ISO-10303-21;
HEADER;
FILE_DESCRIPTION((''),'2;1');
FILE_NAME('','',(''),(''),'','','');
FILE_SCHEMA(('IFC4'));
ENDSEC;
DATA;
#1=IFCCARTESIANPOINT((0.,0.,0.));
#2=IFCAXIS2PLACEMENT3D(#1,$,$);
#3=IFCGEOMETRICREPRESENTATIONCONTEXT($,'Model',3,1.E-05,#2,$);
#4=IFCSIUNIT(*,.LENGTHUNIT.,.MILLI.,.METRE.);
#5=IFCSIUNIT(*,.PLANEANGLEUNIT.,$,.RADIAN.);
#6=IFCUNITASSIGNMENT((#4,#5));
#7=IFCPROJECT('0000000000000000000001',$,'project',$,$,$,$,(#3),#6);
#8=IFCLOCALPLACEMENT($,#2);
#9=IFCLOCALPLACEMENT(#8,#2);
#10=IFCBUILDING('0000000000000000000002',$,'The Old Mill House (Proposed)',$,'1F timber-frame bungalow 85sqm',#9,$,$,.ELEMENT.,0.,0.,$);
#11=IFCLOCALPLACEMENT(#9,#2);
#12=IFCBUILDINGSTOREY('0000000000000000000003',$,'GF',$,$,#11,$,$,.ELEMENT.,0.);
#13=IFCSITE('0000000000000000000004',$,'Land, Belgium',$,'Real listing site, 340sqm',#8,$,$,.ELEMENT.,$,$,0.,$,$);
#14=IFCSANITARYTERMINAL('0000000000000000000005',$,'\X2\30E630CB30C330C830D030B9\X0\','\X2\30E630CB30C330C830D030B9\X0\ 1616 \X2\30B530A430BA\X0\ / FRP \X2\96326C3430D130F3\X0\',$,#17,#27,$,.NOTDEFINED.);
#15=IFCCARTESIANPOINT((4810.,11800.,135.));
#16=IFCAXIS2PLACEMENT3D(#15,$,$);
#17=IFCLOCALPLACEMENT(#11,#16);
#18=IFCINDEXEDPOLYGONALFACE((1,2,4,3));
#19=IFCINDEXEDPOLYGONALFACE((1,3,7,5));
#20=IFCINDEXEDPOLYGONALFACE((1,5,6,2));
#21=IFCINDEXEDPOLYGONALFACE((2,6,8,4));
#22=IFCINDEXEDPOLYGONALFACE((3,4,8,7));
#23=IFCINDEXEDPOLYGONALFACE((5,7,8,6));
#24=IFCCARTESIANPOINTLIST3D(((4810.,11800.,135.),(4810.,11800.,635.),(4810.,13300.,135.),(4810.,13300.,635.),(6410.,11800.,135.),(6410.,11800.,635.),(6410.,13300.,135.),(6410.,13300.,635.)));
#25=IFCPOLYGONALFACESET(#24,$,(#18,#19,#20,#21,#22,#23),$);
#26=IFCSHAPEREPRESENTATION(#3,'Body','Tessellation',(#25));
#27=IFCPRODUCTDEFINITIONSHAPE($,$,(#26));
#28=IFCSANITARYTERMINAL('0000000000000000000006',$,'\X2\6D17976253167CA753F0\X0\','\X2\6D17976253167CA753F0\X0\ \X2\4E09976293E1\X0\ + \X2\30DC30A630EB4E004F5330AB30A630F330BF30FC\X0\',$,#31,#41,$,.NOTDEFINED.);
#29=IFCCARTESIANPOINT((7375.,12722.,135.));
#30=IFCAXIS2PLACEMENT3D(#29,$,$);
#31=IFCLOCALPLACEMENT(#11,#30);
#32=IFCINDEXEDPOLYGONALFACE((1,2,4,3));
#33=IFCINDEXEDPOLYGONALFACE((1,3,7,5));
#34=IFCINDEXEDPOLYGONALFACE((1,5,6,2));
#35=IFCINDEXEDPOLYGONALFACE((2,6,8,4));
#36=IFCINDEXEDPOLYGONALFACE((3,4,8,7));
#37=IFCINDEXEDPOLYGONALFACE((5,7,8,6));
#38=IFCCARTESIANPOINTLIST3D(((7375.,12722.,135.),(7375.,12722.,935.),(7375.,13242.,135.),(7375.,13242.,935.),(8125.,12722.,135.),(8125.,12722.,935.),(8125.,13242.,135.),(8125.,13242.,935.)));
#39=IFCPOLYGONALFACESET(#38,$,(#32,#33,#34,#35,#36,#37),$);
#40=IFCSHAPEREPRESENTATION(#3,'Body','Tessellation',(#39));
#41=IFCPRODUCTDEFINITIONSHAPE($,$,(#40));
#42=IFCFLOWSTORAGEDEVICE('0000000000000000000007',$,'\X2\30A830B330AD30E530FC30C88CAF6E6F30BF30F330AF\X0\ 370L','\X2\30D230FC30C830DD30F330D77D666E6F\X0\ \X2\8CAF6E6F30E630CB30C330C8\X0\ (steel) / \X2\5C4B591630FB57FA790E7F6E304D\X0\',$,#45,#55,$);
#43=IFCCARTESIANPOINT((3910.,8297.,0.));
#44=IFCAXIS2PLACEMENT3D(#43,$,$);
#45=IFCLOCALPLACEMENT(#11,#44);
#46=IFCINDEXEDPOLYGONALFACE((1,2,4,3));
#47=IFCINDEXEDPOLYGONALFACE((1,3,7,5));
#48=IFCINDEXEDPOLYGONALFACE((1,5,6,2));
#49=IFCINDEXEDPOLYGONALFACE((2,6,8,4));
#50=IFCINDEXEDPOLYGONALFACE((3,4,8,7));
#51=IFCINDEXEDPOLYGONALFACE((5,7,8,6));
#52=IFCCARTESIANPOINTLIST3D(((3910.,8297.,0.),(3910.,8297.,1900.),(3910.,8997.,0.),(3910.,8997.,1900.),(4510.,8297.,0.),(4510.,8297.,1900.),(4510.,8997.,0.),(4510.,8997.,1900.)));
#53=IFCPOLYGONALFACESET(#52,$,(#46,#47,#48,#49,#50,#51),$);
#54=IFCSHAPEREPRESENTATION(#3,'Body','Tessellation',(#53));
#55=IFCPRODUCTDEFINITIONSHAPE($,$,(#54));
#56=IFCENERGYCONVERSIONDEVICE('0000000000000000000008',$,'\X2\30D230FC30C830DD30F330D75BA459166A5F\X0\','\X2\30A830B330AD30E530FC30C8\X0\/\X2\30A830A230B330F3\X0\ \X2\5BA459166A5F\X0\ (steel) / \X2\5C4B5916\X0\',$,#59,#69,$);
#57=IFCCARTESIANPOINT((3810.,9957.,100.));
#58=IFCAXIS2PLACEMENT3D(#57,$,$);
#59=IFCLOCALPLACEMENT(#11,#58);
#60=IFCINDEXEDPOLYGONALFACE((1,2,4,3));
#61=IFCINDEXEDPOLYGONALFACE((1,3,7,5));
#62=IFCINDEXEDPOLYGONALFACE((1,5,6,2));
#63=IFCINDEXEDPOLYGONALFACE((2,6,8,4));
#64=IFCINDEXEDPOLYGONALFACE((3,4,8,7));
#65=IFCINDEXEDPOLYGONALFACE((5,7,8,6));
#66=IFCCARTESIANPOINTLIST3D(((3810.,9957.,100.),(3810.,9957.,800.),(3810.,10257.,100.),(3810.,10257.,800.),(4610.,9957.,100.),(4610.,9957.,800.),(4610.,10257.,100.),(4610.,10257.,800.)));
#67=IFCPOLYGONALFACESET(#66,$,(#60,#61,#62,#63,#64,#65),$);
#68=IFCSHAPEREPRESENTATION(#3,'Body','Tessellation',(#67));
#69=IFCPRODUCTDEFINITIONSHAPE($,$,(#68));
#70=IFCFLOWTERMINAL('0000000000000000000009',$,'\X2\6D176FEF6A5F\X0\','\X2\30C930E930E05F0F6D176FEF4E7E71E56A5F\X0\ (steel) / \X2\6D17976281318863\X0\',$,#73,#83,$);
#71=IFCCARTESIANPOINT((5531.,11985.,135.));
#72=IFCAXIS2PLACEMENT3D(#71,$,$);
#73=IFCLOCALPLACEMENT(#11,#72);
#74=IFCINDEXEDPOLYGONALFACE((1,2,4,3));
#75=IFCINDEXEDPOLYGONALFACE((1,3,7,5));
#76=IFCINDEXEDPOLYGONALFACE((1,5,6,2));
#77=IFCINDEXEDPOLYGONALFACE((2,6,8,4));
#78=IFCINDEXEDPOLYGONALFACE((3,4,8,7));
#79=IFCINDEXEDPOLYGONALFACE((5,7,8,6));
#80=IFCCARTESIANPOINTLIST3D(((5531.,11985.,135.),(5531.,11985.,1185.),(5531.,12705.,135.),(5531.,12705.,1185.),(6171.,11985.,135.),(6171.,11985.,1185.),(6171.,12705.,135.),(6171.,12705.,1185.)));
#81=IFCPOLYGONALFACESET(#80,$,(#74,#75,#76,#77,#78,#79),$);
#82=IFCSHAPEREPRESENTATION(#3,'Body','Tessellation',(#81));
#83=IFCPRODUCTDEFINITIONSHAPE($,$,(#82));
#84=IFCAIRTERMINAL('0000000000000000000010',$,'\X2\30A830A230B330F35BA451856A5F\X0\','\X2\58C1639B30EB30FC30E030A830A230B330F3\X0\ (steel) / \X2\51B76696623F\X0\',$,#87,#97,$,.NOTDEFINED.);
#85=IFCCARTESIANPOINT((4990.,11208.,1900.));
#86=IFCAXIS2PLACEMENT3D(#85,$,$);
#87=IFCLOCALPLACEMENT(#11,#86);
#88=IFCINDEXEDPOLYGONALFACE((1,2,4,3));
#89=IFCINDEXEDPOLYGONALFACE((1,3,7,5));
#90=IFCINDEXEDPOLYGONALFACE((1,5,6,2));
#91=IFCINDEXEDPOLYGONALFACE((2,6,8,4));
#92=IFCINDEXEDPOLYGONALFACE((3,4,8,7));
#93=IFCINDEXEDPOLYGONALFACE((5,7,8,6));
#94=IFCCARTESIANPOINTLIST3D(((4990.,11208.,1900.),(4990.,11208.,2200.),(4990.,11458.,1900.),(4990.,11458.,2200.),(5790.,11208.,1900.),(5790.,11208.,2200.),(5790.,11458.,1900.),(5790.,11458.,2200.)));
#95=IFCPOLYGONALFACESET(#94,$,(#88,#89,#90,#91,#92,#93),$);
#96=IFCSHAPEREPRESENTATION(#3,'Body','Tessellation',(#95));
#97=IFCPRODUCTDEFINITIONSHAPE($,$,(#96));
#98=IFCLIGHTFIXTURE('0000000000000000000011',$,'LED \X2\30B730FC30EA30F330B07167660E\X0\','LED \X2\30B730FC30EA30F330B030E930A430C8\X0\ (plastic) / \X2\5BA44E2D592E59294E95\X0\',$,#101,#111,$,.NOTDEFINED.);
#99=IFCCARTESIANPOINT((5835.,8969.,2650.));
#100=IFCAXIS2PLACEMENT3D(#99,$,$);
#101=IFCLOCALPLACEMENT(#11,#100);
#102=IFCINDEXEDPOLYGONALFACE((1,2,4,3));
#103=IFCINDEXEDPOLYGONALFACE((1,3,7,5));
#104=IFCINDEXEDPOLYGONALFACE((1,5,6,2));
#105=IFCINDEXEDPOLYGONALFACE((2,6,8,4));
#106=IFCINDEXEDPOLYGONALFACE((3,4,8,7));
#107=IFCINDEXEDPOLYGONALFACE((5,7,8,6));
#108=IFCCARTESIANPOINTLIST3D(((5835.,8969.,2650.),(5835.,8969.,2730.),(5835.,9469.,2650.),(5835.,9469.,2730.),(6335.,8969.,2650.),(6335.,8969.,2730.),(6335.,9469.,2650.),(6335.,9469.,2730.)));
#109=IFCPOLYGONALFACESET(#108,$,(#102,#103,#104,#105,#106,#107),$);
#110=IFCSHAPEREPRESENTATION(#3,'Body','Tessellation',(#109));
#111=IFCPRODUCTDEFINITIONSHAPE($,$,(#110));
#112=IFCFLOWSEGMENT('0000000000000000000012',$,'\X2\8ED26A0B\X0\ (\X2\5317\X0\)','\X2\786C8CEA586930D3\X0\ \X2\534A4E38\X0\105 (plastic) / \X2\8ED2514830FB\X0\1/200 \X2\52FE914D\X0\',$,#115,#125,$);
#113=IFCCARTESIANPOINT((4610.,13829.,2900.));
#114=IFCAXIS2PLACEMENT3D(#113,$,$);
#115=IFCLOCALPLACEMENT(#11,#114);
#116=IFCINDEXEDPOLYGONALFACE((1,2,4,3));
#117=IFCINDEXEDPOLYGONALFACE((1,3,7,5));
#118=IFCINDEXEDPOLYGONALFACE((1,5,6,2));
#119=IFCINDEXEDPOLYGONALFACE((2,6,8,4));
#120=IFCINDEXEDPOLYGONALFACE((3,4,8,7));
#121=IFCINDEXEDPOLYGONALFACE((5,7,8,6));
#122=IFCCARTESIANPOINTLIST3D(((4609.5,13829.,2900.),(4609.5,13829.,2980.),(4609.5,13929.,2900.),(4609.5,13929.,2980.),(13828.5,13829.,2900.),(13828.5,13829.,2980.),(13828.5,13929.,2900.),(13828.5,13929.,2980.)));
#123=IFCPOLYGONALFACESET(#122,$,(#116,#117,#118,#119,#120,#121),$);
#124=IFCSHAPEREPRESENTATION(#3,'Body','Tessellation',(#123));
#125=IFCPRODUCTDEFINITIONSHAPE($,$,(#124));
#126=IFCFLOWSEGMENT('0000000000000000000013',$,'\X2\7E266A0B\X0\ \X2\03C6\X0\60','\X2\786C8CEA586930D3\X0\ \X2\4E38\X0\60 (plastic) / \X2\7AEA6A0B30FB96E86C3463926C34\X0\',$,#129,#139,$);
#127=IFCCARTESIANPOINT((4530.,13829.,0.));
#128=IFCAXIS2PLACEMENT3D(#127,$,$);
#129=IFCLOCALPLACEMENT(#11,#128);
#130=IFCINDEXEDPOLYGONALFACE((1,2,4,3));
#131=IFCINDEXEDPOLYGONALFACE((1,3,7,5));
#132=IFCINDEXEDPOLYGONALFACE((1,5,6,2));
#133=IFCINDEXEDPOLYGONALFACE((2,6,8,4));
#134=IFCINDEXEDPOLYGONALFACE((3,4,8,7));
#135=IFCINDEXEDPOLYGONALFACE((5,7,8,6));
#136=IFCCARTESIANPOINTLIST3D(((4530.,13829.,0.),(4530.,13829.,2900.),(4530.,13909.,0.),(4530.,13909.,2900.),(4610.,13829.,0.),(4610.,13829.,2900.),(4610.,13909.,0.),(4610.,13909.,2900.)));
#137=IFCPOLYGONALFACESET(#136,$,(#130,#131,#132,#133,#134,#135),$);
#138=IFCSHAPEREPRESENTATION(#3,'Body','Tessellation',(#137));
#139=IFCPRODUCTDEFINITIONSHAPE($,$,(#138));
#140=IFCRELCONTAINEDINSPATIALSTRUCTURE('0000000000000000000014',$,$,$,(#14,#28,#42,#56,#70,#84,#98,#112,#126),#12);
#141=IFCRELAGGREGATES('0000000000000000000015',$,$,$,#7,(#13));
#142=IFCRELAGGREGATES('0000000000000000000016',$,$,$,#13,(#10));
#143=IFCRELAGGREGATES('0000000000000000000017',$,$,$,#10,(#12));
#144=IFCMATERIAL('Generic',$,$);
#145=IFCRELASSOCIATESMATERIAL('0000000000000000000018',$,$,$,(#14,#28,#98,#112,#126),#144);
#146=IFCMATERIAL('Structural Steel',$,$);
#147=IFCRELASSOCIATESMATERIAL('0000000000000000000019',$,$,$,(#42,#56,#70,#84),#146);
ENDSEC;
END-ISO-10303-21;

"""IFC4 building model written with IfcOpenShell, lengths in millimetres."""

from ifc_helpers import new_model, si_unit, frame, frame_2d, origin, place, context, project, spatial, rectangle, extrude, material, element, save


model = new_model("IFC4")

# Units and contexts
model_context = context("Model", 3, precision=1e-05, world=origin())
ifc_project = project(units=[si_unit("LENGTHUNIT", "METRE", prefix="MILLI"), si_unit("PLANEANGLEUNIT", "RADIAN")], contexts=[model_context])

# Site, building, storey
site_placement = place(None, origin())
site = spatial("IfcSite", under=ifc_project, at=site_placement, Name="Land, Belgium", ObjectType="Real listing site, 340sqm", CompositionType="ELEMENT", RefElevation=0.0)
building_placement = place(site_placement, origin())
building = spatial("IfcBuilding", under=site, at=building_placement, Name="The Old Mill House (Proposed)", ObjectType="1F timber-frame bungalow 85sqm", CompositionType="ELEMENT", ElevationOfRefHeight=0.0, ElevationOfTerrain=0.0)
storey_placement = place(building_placement, origin())
storey = spatial("IfcBuildingStorey", under=building, at=storey_placement, Name="GF", CompositionType="ELEMENT", Elevation=0.0)

# Shared definitions
ifc_material_1 = material(Name="Structural Steel")

# Shared definitions
ifc_material_2 = material(Name="Generic")

# Sanitary terminals
sanitary_terminal_1_placement = place(storey_placement, frame((4810.0, 11800.0, 135.0)))
element("IfcSanitaryTerminal", 1, at=sanitary_terminal_1_placement, inside=storey, material=ifc_material_2, Name="ユニットバス", Description="ユニットバス 1616 サイズ / FRP 防水パン", PredefinedType="NOTDEFINED", context=model_context, shape_type="SweptSolid", body=[
    extrude(rectangle(XDim=1600.0, YDim=1500.0, at=frame_2d((800.0, 750.0))), frame((4810.0, 11800.0, 135.0)), (0.0, 0.0, 1.0), 500.0),
])
sanitary_terminal_2_placement = place(storey_placement, frame((7375.0, 12722.0, 135.0)))
element("IfcSanitaryTerminal", 2, at=sanitary_terminal_2_placement, inside=storey, material=ifc_material_2, Name="洗面化粧台", Description="洗面化粧台 三面鏡 + ボウル一体カウンター", PredefinedType="NOTDEFINED", context=model_context, shape_type="SweptSolid", body=[
    extrude(rectangle(XDim=750.0, YDim=520.0, at=frame_2d((375.0, 260.0))), frame((7375.0, 12722.0, 135.0)), (0.0, 0.0, 1.0), 800.0),
])

# Flow storage device
flow_storage_device_placement = place(storey_placement, frame((3910.0, 8297.0, 0.0)))
element("IfcFlowStorageDevice", 3, at=flow_storage_device_placement, inside=storey, material=ifc_material_1, Name="エコキュート貯湯タンク 370L", Description="ヒートポンプ給湯 貯湯ユニット (steel) / 屋外・基礎置き", context=model_context, shape_type="SweptSolid", body=[
    extrude(rectangle(XDim=600.0, YDim=700.0, at=frame_2d((300.0, 350.0))), frame((3910.0, 8297.0, 0.0)), (0.0, 0.0, 1.0), 1900.0),
])

# Energy conversion device
energy_conversion_device_placement = place(storey_placement, frame((3810.0, 9957.0, 100.0)))
element("IfcEnergyConversionDevice", 4, at=energy_conversion_device_placement, inside=storey, material=ifc_material_1, Name="ヒートポンプ室外機", Description="エコキュート/エアコン 室外機 (steel) / 屋外", context=model_context, shape_type="SweptSolid", body=[
    extrude(rectangle(XDim=800.0, YDim=300.0, at=frame_2d((400.0, 150.0))), frame((3810.0, 9957.0, 100.0)), (0.0, 0.0, 1.0), 700.0),
])

# Flow terminal
flow_terminal_placement = place(storey_placement, frame((5531.0, 11985.0, 135.0)))
element("IfcFlowTerminal", 5, at=flow_terminal_placement, inside=storey, material=ifc_material_1, Name="洗濯機", Description="ドラム式洗濯乾燥機 (steel) / 洗面脱衣", context=model_context, shape_type="SweptSolid", body=[
    extrude(rectangle(XDim=640.0, YDim=720.0, at=frame_2d((320.0, 360.0))), frame((5531.0, 11985.0, 135.0)), (0.0, 0.0, 1.0), 1050.0),
])

# Air terminal
air_terminal_placement = place(storey_placement, frame((4990.0, 11208.0, 1900.0)))
element("IfcAirTerminal", 6, at=air_terminal_placement, inside=storey, material=ifc_material_1, Name="エアコン室内機", Description="壁掛ルームエアコン (steel) / 冷暖房", PredefinedType="NOTDEFINED", context=model_context, shape_type="SweptSolid", body=[
    extrude(rectangle(XDim=800.0, YDim=250.0, at=frame_2d((400.0, 125.0))), frame((4990.0, 11208.0, 1900.0)), (0.0, 0.0, 1.0), 300.0),
])

# Light fixture
light_fixture_placement = place(storey_placement, frame((5835.0, 8969.0, 2650.0)))
element("IfcLightFixture", 7, at=light_fixture_placement, inside=storey, material=ifc_material_2, Name="LED シーリング照明", Description="LED シーリングライト (plastic) / 室中央天井", PredefinedType="NOTDEFINED", context=model_context, shape_type="SweptSolid", body=[
    extrude(rectangle(XDim=500.0, YDim=500.0, at=frame_2d((250.0, 250.0))), frame((5835.0, 8969.0, 2650.0)), (0.0, 0.0, 1.0), 80.0),
])

# Flow segments
flow_segment_1_placement = place(storey_placement, frame((4610.0, 13829.0, 2900.0)))
element("IfcFlowSegment", 8, at=flow_segment_1_placement, inside=storey, material=ifc_material_2, Name="軒樋 (北)", Description="硬質塩ビ 半丸105 (plastic) / 軒先・1/200 勾配", context=model_context, shape_type="SweptSolid", body=[
    extrude(rectangle(XDim=9219.0, YDim=100.0, at=frame_2d((4609.0, 50.0))), frame((4610.0, 13829.0, 2900.0)), (0.0, 0.0, 1.0), 80.0),
])
flow_segment_2_placement = place(storey_placement, frame((4530.0, 13829.0, 0.0)))
element("IfcFlowSegment", 9, at=flow_segment_2_placement, inside=storey, material=ifc_material_2, Name="縦樋 φ60", Description="硬質塩ビ 丸60 (plastic) / 竪樋・雨水排水", context=model_context, shape_type="SweptSolid", body=[
    extrude(rectangle(XDim=80.0, YDim=80.0, at=frame_2d((40.0, 40.0))), frame((4530.0, 13829.0, 0.0)), (0.0, 0.0, 1.0), 2900.0),
])

save(model, "model.ifc")
